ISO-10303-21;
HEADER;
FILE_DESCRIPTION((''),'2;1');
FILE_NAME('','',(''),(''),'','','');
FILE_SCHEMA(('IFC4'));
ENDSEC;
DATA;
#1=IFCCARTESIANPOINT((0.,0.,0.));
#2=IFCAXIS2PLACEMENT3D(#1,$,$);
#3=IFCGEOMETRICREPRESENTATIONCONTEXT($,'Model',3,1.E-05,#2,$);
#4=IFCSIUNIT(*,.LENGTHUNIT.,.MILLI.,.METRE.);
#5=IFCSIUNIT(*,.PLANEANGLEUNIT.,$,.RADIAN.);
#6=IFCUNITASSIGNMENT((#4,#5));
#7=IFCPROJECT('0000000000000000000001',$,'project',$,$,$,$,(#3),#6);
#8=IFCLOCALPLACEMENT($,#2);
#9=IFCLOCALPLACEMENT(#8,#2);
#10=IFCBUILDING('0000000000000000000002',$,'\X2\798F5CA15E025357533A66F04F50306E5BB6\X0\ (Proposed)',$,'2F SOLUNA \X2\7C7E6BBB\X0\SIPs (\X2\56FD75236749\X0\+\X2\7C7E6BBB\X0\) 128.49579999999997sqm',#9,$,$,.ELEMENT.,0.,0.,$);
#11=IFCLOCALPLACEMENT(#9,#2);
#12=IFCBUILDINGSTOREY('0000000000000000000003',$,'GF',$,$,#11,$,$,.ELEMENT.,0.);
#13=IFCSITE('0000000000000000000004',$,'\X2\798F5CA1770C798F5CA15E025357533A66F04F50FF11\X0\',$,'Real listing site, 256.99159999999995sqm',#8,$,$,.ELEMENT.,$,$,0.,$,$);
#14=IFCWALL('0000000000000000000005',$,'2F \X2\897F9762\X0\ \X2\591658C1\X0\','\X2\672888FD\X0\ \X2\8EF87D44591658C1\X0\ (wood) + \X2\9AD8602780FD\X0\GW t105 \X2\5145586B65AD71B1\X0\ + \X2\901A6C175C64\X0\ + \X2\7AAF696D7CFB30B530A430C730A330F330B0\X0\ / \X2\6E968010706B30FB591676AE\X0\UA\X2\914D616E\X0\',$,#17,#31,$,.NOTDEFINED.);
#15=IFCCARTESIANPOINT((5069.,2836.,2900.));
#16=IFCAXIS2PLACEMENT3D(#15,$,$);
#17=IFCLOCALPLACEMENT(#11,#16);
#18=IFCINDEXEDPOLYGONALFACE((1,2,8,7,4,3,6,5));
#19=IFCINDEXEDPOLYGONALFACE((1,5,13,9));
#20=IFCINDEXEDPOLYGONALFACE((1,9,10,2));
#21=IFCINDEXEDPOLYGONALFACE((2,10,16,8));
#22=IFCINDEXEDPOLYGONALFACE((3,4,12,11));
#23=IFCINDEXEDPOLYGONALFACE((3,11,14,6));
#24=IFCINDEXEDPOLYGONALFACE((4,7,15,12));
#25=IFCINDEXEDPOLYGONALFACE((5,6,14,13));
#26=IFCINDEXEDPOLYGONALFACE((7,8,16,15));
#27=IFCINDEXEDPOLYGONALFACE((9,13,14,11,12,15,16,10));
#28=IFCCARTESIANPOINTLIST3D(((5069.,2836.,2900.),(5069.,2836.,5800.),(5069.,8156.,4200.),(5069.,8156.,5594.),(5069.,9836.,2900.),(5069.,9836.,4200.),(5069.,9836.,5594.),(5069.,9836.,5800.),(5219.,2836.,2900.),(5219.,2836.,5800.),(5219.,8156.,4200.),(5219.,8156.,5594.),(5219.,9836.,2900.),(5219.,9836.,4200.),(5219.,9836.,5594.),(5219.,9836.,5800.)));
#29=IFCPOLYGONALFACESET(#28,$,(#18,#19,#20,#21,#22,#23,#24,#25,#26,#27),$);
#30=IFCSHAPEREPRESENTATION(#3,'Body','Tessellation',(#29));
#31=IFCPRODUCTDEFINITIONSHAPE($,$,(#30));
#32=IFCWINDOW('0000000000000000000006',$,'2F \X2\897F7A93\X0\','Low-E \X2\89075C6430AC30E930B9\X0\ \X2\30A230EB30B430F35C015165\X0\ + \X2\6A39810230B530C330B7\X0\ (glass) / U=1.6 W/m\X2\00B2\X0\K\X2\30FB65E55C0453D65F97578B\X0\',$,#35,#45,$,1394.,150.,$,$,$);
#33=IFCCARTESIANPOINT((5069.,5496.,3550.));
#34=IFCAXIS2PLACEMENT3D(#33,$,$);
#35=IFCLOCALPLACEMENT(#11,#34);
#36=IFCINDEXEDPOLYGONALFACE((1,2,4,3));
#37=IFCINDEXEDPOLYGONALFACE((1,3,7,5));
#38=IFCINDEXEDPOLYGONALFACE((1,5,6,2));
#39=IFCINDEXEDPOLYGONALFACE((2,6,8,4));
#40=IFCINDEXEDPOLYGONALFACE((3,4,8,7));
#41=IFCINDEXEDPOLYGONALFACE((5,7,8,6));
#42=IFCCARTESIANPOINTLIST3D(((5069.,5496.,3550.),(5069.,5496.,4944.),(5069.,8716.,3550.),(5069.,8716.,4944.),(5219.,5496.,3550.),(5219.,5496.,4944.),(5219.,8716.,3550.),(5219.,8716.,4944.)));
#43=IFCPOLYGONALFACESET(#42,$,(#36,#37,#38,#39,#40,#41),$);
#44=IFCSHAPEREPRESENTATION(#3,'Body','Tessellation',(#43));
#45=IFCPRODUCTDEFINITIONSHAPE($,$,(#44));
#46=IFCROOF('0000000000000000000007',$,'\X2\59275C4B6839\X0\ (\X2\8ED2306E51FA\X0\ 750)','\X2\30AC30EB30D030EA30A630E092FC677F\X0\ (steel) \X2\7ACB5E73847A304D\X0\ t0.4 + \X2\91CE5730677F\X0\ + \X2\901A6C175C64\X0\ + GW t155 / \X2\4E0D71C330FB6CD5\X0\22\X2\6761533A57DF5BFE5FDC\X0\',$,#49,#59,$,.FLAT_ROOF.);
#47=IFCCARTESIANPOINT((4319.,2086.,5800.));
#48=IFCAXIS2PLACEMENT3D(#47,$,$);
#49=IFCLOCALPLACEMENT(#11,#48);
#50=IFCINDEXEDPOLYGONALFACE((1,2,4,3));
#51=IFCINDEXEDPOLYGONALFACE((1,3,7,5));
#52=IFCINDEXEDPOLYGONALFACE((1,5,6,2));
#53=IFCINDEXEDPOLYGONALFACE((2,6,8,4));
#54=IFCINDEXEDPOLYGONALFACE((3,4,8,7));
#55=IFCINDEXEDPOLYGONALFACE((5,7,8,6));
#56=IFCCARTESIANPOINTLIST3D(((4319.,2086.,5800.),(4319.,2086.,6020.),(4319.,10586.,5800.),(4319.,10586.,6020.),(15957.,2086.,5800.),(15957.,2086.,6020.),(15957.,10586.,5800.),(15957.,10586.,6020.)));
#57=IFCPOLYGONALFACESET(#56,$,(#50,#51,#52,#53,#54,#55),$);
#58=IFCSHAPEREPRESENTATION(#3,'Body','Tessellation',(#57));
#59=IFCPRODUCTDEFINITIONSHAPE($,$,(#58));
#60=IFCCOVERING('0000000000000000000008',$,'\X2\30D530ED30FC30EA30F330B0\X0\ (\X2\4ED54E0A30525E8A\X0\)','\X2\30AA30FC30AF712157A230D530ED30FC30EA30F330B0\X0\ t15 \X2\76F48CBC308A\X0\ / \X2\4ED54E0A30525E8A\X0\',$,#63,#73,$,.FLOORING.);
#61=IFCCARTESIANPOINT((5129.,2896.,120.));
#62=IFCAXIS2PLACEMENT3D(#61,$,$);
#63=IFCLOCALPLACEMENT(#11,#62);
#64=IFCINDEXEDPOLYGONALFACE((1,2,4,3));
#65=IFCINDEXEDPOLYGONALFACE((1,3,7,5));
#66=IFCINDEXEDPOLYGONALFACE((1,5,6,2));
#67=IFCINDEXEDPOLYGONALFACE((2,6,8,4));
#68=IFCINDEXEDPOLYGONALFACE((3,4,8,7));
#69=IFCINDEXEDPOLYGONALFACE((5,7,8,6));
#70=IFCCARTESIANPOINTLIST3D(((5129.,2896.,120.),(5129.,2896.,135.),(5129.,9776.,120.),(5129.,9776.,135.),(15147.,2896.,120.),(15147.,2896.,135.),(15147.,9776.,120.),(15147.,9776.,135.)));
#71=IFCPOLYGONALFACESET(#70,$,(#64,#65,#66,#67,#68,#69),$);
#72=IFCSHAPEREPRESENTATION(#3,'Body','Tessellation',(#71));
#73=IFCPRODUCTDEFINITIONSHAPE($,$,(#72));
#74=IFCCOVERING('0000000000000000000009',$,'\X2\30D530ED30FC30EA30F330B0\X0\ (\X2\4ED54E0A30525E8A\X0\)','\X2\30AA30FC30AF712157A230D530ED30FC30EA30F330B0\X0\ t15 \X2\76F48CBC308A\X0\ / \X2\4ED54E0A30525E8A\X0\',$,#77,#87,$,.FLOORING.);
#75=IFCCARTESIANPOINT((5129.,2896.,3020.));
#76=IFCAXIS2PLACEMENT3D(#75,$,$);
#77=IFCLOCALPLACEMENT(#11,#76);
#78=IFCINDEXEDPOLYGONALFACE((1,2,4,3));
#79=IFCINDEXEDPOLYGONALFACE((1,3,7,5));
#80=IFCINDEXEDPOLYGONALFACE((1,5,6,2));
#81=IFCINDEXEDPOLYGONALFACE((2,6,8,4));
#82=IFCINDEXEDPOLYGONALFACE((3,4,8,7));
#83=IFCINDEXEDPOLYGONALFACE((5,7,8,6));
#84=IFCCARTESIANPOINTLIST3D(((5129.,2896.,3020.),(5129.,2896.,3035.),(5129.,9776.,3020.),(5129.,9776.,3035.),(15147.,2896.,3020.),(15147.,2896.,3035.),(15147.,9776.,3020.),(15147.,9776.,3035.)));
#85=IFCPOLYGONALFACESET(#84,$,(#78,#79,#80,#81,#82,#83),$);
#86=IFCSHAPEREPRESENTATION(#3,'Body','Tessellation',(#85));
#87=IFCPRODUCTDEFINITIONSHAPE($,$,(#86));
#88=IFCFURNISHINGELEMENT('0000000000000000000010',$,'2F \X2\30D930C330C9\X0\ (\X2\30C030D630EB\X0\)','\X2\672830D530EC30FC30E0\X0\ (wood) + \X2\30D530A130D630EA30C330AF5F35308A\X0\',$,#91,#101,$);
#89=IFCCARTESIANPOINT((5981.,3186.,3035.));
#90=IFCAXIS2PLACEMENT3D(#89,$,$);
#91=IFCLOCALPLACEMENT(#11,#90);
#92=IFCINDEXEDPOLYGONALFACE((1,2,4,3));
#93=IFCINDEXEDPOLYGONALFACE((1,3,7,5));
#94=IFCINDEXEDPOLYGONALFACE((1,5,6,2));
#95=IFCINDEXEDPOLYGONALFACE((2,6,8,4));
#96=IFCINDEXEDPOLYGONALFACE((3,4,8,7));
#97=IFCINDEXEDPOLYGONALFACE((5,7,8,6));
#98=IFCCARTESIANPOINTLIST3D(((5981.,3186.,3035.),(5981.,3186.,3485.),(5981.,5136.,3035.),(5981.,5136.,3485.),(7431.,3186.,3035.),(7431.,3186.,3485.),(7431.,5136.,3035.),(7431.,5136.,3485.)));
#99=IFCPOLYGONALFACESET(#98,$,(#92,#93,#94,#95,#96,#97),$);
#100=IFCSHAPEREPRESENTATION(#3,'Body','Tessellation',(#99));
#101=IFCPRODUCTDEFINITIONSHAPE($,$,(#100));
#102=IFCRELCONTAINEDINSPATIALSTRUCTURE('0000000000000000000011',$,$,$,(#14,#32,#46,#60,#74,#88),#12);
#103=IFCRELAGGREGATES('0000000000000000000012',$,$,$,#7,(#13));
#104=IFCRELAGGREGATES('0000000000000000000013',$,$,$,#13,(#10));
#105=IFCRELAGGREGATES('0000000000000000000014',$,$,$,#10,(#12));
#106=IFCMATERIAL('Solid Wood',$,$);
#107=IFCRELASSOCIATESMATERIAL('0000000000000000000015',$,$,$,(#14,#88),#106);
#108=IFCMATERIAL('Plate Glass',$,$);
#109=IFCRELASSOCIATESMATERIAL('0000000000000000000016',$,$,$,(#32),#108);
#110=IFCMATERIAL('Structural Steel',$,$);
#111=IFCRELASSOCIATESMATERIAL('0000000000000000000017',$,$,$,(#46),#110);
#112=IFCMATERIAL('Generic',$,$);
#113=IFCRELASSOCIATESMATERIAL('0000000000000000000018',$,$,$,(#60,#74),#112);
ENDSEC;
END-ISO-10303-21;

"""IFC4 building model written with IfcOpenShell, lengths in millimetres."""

from ifc_helpers import new_model, si_unit, frame, frame_2d, origin, place, context, project, spatial, rectangle, extrude, material, element, fill, save


model = new_model("IFC4")

# Units and contexts
model_context = context("Model", 3, precision=1e-05, world=origin())
ifc_project = project(units=[si_unit("LENGTHUNIT", "METRE", prefix="MILLI"), si_unit("PLANEANGLEUNIT", "RADIAN")], contexts=[model_context])

# Site, building, storey
site_placement = place(None, origin())
site = spatial("IfcSite", under=ifc_project, at=site_placement, Name="福岡県福岡市南区曰佐１", ObjectType="Real listing site, 256.99159999999995sqm", CompositionType="ELEMENT", RefElevation=0.0)
building_placement = place(site_placement, origin())
building = spatial("IfcBuilding", under=site, at=building_placement, Name="福岡市南区曰佐の家 (Proposed)", ObjectType="2F SOLUNA 籾殻SIPs (国産杉+籾殻) 128.49579999999997sqm", CompositionType="ELEMENT", ElevationOfRefHeight=0.0, ElevationOfTerrain=0.0)
storey_placement = place(building_placement, origin())
storey = spatial("IfcBuildingStorey", under=building, at=storey_placement, Name="GF", CompositionType="ELEMENT", Elevation=0.0)

# Shared definitions
ifc_material_1 = material(Name="Solid Wood")

# Shared definitions
ifc_material_2 = material(Name="Plate Glass")

# Wall, opening, window
wall_1_placement = place(storey_placement, frame((5069.0, 2836.0, 2900.0)))
wall_1 = element("IfcWall", 1, at=wall_1_placement, inside=storey, material=ifc_material_1, Name="2F 西面 外壁", Description="木製 軸組外壁 (wood) + 高性能GW t105 充填断熱 + 通気層 + 窯業系サイディング / 準耐火・外皮UA配慮", PredefinedType="NOTDEFINED", context=model_context, shape_type="SweptSolid", body=[
    extrude(rectangle(XDim=150.0, YDim=7000.0, at=frame_2d((75.0, 3500.0))), frame((5069.0, 2836.0, 2900.0)), (0.0, 0.0, 1.0), 2900.0),
])
opening_1_placement = place(storey_placement, frame((5069.0, 5496.0, 3550.0)))
opening_1 = element("IfcOpeningElement", 2, at=opening_1_placement, cuts=wall_1, PredefinedType="NOTDEFINED", context=model_context, shape_type="SweptSolid", body=[
    extrude(rectangle(XDim=150.0, YDim=3220.0, at=frame_2d((75.0, 1610.0))), frame((5069.0, 5496.0, 3550.0)), (0.0, 0.0, 1.0), 1394.0),
])
window_1_placement = place(storey_placement, frame((5069.0, 5496.0, 3550.0)))
window_1 = element("IfcWindow", 3, at=window_1_placement, inside=storey, material=ifc_material_2, Name="2F 西窓", Description="Low-E 複層ガラス アルゴン封入 + 樹脂サッシ (glass) / U=1.6 W/m²K・日射取得型", OverallHeight=1394.0, OverallWidth=150.0, context=model_context, shape_type="SweptSolid", body=[
    extrude(rectangle(XDim=150.0, YDim=3220.0, at=frame_2d((75.0, 1610.0))), frame((5069.0, 5496.0, 3550.0)), (0.0, 0.0, 1.0), 1394.0),
])
fill(opening_1, window_1)

# Roof
ifc_material_3 = material(Name="Structural Steel")
roof_placement = place(storey_placement, frame((4319.0, 2086.0, 5800.0)))
element("IfcRoof", 4, at=roof_placement, inside=storey, material=ifc_material_3, Name="大屋根 (軒の出 750)", Description="ガルバリウム鋼板 (steel) 立平葺き t0.4 + 野地板 + 通気層 + GW t155 / 不燃・法22条区域対応", PredefinedType="FLAT_ROOF", context=model_context, shape_type="SweptSolid", body=[
    extrude(rectangle(XDim=11638.0, YDim=8500.0, at=frame_2d((5819.0, 4250.0))), frame((4319.0, 2086.0, 5800.0)), (0.0, 0.0, 1.0), 220.0),
])

# Coverings
ifc_material_4 = material(Name="Generic")
covering_1_placement = place(storey_placement, frame((5129.0, 2896.0, 120.0)))
element("IfcCovering", 5, at=covering_1_placement, inside=storey, material=ifc_material_4, Name="フローリング (仕上げ床)", Description="オーク無垢フローリング t15 直貼り / 仕上げ床", PredefinedType="FLOORING", context=model_context, shape_type="SweptSolid", body=[
    extrude(rectangle(XDim=10018.0, YDim=6880.0, at=frame_2d((5009.0, 3440.0))), frame((5129.0, 2896.0, 120.0)), (0.0, 0.0, 1.0), 15.0),
])
covering_2_placement = place(storey_placement, frame((5129.0, 2896.0, 3020.0)))
element("IfcCovering", 6, at=covering_2_placement, inside=storey, material=ifc_material_4, Name="フローリング (仕上げ床)", Description="オーク無垢フローリング t15 直貼り / 仕上げ床", PredefinedType="FLOORING", context=model_context, shape_type="SweptSolid", body=[
    extrude(rectangle(XDim=10018.0, YDim=6880.0, at=frame_2d((5009.0, 3440.0))), frame((5129.0, 2896.0, 3020.0)), (0.0, 0.0, 1.0), 15.0),
])

# Furnishing element
furnishing_placement = place(storey_placement, frame((5981.0, 3186.0, 3035.0)))
element("IfcFurnishingElement", 7, at=furnishing_placement, inside=storey, material=ifc_material_1, Name="2F ベッド (ダブル)", Description="木フレーム (wood) + ファブリック張り", context=model_context, shape_type="SweptSolid", body=[
    extrude(rectangle(XDim=1450.0, YDim=1950.0, at=frame_2d((725.0, 975.0))), frame((5981.0, 3186.0, 3035.0)), (0.0, 0.0, 1.0), 450.0),
])

save(model, "model.ifc")
